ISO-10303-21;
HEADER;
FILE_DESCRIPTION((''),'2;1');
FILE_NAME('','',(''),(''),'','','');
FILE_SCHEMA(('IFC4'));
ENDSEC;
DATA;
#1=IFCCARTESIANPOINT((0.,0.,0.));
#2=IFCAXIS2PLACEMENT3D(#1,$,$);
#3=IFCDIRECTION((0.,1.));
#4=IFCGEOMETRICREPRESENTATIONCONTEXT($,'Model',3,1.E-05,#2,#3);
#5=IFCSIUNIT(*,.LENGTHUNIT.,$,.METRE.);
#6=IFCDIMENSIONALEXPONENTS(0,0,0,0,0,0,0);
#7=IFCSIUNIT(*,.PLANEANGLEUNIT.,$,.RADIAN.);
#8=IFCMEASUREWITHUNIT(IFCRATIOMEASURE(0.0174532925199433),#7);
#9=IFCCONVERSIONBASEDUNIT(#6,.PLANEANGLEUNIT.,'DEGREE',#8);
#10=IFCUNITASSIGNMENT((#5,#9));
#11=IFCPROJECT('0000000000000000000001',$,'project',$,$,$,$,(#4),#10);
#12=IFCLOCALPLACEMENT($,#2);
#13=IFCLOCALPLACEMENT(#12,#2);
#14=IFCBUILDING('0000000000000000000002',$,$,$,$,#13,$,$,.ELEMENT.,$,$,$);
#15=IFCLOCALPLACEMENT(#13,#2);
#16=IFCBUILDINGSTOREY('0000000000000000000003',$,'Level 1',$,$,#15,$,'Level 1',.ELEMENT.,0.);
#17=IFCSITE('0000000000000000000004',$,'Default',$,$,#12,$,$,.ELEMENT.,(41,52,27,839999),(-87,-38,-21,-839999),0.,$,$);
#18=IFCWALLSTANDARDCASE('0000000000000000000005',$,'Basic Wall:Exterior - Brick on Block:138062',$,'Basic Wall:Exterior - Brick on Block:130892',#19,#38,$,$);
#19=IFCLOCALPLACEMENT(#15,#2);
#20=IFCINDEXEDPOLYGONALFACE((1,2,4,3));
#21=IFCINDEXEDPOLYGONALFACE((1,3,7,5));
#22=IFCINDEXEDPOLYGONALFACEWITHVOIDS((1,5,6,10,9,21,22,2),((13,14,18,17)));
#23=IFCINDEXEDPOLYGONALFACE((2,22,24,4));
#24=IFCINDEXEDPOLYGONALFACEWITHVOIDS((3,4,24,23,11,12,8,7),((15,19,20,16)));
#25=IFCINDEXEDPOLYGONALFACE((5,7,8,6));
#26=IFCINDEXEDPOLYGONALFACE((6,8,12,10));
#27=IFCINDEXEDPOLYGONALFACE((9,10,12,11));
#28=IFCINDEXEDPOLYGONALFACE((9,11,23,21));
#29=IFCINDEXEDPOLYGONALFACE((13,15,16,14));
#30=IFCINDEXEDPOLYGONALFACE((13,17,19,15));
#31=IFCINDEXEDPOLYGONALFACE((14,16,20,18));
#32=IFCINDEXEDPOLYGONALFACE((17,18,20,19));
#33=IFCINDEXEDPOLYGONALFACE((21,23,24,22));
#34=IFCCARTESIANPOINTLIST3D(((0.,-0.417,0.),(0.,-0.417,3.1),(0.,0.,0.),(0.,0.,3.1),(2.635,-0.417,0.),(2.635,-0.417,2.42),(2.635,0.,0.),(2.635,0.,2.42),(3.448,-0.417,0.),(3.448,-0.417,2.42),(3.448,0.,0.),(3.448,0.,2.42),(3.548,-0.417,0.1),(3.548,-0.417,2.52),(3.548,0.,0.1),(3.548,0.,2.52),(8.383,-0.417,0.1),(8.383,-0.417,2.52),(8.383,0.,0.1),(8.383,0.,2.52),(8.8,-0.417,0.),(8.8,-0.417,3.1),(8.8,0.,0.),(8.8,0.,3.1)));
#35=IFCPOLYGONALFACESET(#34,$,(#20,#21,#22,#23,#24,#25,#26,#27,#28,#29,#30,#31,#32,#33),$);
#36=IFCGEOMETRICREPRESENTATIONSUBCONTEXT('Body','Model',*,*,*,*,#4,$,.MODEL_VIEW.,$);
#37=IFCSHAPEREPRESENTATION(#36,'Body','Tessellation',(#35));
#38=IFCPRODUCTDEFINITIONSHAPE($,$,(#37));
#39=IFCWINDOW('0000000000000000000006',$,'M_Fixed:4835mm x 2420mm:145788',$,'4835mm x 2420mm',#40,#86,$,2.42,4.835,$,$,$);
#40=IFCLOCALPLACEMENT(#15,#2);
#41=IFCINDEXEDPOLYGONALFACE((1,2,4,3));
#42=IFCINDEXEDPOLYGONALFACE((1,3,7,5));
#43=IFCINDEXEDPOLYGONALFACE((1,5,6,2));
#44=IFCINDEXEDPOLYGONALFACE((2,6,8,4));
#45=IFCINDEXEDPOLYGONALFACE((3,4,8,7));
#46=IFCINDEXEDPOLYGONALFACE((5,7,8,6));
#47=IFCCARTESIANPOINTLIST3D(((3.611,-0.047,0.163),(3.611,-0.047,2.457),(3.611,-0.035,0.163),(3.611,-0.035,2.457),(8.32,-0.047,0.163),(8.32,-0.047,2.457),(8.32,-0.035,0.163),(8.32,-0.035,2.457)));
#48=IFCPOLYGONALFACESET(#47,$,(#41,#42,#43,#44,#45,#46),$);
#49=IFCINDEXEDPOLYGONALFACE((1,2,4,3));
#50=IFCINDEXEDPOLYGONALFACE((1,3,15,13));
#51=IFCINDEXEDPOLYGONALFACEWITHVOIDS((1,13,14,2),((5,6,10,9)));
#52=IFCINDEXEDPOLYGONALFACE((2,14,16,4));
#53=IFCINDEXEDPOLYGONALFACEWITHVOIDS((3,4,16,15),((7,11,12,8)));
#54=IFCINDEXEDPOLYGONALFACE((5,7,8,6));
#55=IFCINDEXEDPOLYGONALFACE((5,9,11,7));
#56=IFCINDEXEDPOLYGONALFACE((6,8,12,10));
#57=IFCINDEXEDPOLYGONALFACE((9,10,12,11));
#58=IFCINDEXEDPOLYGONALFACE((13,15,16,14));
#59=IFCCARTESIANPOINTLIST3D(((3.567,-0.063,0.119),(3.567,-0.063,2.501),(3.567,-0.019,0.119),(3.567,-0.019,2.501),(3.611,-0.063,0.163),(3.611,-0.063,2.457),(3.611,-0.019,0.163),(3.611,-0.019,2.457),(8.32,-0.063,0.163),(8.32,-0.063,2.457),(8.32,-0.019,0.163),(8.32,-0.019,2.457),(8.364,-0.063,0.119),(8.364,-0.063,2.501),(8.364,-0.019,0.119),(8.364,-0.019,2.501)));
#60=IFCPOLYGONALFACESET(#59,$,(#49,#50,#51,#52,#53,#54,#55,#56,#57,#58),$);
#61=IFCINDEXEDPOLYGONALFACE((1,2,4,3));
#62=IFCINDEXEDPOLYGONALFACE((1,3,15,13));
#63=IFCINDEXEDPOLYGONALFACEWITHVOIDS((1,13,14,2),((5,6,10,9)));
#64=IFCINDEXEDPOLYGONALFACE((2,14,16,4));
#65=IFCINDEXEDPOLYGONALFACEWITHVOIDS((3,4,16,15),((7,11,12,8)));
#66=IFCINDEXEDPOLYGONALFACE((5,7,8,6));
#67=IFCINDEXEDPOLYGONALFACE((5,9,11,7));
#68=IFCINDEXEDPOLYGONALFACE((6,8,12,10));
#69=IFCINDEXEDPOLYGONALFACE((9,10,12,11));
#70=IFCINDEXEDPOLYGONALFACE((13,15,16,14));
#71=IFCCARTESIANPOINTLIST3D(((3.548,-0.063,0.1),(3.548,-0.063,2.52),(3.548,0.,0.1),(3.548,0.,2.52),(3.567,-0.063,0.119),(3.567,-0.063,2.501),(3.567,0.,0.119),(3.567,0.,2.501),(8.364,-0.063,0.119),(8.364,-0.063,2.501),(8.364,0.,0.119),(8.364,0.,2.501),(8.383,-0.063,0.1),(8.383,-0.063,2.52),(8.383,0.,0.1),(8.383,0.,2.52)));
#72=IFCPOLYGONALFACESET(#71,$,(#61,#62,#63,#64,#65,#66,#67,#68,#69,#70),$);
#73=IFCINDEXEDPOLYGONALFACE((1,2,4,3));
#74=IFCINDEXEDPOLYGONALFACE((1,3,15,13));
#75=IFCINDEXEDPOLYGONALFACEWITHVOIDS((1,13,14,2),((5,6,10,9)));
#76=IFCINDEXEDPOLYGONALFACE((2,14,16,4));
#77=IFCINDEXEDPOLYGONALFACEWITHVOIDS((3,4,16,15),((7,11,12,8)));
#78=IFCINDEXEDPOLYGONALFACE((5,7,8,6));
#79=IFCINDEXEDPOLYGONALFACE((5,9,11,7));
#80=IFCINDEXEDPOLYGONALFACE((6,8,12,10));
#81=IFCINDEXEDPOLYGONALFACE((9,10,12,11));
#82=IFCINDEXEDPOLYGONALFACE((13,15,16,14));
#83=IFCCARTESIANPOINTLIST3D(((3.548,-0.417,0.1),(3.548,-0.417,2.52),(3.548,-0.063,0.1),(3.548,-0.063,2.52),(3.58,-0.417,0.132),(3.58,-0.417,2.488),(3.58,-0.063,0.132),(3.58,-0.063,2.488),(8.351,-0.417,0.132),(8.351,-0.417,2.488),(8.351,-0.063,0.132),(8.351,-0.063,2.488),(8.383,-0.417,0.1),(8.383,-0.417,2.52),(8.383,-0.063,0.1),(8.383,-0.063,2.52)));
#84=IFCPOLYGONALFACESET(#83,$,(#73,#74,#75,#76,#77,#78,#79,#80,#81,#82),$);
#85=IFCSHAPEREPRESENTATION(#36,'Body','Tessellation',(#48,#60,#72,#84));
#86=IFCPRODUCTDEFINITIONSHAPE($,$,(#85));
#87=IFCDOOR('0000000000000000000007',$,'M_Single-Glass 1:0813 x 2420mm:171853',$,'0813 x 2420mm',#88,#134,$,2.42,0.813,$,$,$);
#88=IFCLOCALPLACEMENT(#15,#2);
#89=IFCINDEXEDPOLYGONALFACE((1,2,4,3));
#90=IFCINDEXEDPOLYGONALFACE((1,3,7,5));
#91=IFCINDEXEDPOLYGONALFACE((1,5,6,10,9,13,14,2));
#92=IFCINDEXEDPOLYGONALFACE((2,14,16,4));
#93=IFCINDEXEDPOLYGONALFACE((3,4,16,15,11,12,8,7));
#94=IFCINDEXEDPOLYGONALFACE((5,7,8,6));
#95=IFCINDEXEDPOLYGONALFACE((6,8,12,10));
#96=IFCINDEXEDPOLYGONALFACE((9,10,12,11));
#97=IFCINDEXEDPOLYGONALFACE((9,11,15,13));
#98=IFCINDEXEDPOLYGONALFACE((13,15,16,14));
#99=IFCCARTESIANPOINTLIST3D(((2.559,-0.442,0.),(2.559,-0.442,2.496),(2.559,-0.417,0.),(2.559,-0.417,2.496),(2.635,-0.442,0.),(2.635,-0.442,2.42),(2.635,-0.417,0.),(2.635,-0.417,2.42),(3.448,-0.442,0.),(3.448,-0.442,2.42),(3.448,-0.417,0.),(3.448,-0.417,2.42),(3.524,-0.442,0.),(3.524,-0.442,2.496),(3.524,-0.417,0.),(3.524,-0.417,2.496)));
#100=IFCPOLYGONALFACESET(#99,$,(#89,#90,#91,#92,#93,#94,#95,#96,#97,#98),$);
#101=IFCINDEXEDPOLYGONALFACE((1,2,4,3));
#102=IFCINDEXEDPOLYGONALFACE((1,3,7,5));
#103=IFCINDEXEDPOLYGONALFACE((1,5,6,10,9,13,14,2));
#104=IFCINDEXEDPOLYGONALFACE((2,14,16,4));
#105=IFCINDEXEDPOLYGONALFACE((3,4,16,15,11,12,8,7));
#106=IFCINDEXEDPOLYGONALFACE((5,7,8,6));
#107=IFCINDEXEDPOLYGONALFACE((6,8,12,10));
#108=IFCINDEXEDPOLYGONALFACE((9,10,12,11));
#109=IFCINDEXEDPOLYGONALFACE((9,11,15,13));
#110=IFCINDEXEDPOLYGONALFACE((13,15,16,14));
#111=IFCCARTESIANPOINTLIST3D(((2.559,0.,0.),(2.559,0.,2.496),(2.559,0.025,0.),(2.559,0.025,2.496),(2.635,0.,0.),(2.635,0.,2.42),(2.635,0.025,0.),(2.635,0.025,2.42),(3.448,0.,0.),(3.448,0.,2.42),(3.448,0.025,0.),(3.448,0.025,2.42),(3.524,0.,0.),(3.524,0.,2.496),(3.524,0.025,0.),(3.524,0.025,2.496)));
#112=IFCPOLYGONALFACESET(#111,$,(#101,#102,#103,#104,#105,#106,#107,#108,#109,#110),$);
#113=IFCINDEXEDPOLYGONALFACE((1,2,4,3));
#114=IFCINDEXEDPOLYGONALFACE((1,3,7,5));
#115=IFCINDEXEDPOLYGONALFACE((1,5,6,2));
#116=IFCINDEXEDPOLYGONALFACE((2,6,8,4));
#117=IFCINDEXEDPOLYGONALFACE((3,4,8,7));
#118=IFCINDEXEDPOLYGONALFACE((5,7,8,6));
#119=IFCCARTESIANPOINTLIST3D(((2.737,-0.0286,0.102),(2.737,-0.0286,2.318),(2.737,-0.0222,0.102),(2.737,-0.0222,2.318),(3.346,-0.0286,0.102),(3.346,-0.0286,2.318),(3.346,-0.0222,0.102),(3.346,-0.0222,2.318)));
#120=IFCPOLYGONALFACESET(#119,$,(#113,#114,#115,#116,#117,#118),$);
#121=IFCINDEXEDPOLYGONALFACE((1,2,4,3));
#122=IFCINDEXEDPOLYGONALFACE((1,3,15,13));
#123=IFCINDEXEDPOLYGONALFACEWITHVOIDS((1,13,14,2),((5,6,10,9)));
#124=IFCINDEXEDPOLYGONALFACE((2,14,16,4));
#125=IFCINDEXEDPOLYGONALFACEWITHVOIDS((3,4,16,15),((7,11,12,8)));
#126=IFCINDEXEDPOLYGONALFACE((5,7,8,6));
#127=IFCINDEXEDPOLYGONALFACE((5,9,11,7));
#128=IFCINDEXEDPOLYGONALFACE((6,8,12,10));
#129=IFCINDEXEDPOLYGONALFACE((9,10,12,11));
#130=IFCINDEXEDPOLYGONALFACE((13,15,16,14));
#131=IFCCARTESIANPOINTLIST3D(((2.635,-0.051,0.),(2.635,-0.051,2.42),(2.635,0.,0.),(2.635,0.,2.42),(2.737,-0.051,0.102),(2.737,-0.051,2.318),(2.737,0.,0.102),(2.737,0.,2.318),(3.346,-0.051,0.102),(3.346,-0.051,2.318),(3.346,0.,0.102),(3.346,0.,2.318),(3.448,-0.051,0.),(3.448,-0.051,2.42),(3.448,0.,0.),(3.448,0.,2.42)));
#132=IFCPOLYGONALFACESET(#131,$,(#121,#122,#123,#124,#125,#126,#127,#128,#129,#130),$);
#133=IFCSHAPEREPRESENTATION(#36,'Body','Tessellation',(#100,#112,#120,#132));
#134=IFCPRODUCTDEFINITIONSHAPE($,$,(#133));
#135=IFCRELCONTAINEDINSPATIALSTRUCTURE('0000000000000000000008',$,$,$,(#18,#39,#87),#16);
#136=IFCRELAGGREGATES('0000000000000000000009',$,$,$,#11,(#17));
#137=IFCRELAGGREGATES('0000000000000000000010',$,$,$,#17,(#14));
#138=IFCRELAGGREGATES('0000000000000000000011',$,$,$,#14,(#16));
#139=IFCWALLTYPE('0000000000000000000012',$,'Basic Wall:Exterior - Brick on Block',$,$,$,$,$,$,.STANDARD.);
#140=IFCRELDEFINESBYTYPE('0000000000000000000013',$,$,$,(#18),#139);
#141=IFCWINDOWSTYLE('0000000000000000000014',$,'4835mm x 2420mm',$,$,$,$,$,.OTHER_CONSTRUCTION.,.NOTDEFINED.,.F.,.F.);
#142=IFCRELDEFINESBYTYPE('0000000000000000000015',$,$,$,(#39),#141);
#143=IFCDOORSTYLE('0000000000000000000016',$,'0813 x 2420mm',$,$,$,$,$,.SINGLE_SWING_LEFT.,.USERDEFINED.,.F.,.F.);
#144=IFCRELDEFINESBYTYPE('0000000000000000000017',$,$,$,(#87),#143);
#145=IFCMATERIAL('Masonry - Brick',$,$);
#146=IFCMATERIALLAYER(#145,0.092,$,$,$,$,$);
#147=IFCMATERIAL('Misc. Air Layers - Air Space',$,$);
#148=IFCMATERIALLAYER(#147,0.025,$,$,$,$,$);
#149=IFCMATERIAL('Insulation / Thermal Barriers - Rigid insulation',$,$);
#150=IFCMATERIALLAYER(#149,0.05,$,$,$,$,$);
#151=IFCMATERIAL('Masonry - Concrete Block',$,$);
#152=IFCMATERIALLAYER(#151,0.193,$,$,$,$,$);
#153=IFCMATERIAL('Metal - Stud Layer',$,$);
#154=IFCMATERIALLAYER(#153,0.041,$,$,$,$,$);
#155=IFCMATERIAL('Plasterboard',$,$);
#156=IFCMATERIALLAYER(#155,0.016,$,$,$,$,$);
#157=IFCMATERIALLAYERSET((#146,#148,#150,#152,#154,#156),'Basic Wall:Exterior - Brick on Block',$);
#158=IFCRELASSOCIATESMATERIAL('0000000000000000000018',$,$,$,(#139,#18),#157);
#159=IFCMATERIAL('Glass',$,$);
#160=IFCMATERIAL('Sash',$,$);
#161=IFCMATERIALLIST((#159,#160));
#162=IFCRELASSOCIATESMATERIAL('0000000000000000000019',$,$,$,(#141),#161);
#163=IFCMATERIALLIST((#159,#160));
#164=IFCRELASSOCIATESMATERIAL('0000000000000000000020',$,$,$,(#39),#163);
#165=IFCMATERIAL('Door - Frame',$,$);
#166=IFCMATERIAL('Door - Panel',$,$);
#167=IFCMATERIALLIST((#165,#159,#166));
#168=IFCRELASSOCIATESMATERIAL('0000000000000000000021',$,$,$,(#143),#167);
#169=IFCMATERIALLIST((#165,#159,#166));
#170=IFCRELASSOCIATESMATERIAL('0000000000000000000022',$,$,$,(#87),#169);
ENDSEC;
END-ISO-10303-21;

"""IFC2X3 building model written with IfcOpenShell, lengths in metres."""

from ifc_helpers import new_model, entity, si_unit, converted_unit, direction, frame, frame_2d, origin, origin_2d_with_axis, place, context, subcontext, project, spatial, polyline, rectangle, outline, extrude, source, transform, mapped, material, material_list, layer, layer_set, layer_usage, type_object, type_shapes, element, fill, save


model = new_model("IFC2X3")

# Units and contexts
model_context = context("Model", 3, precision=1e-05, world=origin(), true_north=direction((0.0, 1.0)))
body_context = subcontext(model_context, "Body", "Model", "MODEL_VIEW")
ifc_project = project(units=[si_unit("LENGTHUNIT", "METRE"), converted_unit("PLANEANGLEUNIT", "DEGREE", entity("IfcRatioMeasure", 0.0174532925199433), si_unit("PLANEANGLEUNIT", "RADIAN"), dimensions=[0, 0, 0, 0, 0, 0, 0])], contexts=[model_context])

# Site, building, storey
site_placement = place(None, origin())
site = spatial("IfcSite", under=ifc_project, at=site_placement, Name="Default", CompositionType="ELEMENT", RefLatitude=(41, 52, 27, 839999), RefLongitude=(-87, -38, -21, -839999), RefElevation=0.0)
building_placement = place(site_placement, origin())
building = spatial("IfcBuilding", under=site, at=building_placement, CompositionType="ELEMENT")
storey_placement = place(building_placement, origin())
storey = spatial("IfcBuildingStorey", under=building, at=storey_placement, Name="Level 1", LongName="Level 1", CompositionType="ELEMENT", Elevation=0.0)

# Wall, openings, window, door
ifc_material_1 = material(Name="Masonry - Brick")
ifc_layer_1 = layer(ifc_material_1, 0.092)
ifc_material_2 = material(Name="Misc. Air Layers - Air Space")
ifc_layer_2 = layer(ifc_material_2, 0.025)
ifc_material_3 = material(Name="Insulation / Thermal Barriers - Rigid insulation")
ifc_layer_3 = layer(ifc_material_3, 0.05)
ifc_material_4 = material(Name="Masonry - Concrete Block")
ifc_layer_4 = layer(ifc_material_4, 0.193)
ifc_material_5 = material(Name="Metal - Stud Layer")
ifc_layer_5 = layer(ifc_material_5, 0.041)
ifc_material_6 = material(Name="Plasterboard")
ifc_layer_6 = layer(ifc_material_6, 0.016)
ifc_layer_set_1 = layer_set([ifc_layer_1, ifc_layer_2, ifc_layer_3, ifc_layer_4, ifc_layer_5, ifc_layer_6], Name="Basic Wall:Exterior - Brick on Block")
ifc_layer_usage_1 = layer_usage(ifc_layer_set_1, "AXIS2", "NEGATIVE", 0.2085)
wall_type_1 = type_object("IfcWallType", Name="Basic Wall:Exterior - Brick on Block", PredefinedType="STANDARD", material=ifc_layer_set_1)
wall_1_placement = place(storey_placement, frame((0.0, -0.2085, 0.0)))
wall_1 = element("IfcWallStandardCase", 1, at=wall_1_placement, inside=storey, type_object=wall_type_1, material=ifc_layer_usage_1, Name="Basic Wall:Exterior - Brick on Block:138062", ObjectType="Basic Wall:Exterior - Brick on Block:130892", context=body_context, shape_type="SweptSolid", body=[
    extrude(rectangle(XDim=8.8, YDim=0.417, at=frame_2d((4.4, 0.0), x_axis=(-1.0, 0.0))), origin(), (0.0, 0.0, 1.0), 3.1),
])
opening_1_placement = place(wall_1_placement, frame((2.635, -0.2085, 0.0)))
opening_1 = element("IfcOpeningElement", 2, at=opening_1_placement, cuts=wall_1, ObjectType="Opening", context=body_context, shape_type="SweptSolid", body=[
    extrude(rectangle(XDim=0.813, YDim=2.42, at=frame_2d((1.21, 0.4065), x_axis=(0.0, -1.0))), frame((0.0, 0.0, 0.0), z_axis=(0.0, 1.0, 0.0), x_axis=(0.0, 0.0, 1.0)), (0.0, 0.0, 1.0), 0.417),
])
opening_2_placement = place(wall_1_placement, frame((3.548, -0.2085, 0.1)))
opening_2 = element("IfcOpeningElement", 3, at=opening_2_placement, cuts=wall_1, ObjectType="Opening", context=body_context, shape_type="SweptSolid", body=[
    extrude(rectangle(XDim=2.42, YDim=4.835, at=frame_2d((1.21, 2.4175), x_axis=(1.0, 0.0))), frame((0.0, 0.0, 0.0), z_axis=(0.0, 1.0, 0.0), x_axis=(0.0, 0.0, 1.0)), (0.0, 0.0, 1.0), 0.417),
])
ifc_material_7 = material(Name="Glass")
ifc_material_8 = material(Name="Sash")
ifc_material_list_1 = material_list([ifc_material_7, ifc_material_8])
ifc_material_list_2 = material_list([ifc_material_7, ifc_material_8])
window_style_1 = type_object("IfcWindowStyle", Name="4835mm x 2420mm", ConstructionType="OTHER_CONSTRUCTION", OperationType="NOTDEFINED", ParameterTakesPrecedence=False, Sizeable=False, material=ifc_material_list_2)
shared_shape_1 = source(origin(), body_context, "Body", "SweptSolid", [
    extrude(rectangle(XDim=0.012, YDim=4.709, at=origin_2d_with_axis()), frame((2.4175, 0.376, 0.063), z_axis=(0.0, 0.0, 1.0), x_axis=(0.0, -1.0, 0.0)), (0.0, 0.0, 1.0), 2.294),
    extrude(outline(polyline([(-2.3985, -1.191), (2.3985, -1.191), (2.3985, 1.191), (-2.3985, 1.191), (-2.3985, -1.191)]), holes=[polyline([(-2.3545, -1.147), (-2.3545, 1.147), (2.3545, 1.147), (2.3545, -1.147), (-2.3545, -1.147)])]), frame((2.4175, 0.354, 1.21), z_axis=(0.0, 1.0, 0.0), x_axis=(1.0, 0.0, 0.0)), (0.0, 0.0, 1.0), 0.044),
    extrude(outline(polyline([(-2.4175, -1.21), (2.4175, -1.21), (2.4175, 1.21), (-2.4175, 1.21), (-2.4175, -1.21)]), holes=[polyline([(-2.3985, -1.191), (-2.3985, 1.191), (2.3985, 1.191), (2.3985, -1.191), (-2.3985, -1.191)])]), frame((2.4175, 0.354, 1.21), z_axis=(0.0, 1.0, 0.0), x_axis=(1.0, 0.0, 0.0)), (0.0, 0.0, 1.0), 0.063),
    extrude(outline(polyline([(-2.4175, -1.21), (2.4175, -1.21), (2.4175, 1.21), (-2.4175, 1.21), (-2.4175, -1.21)]), holes=[polyline([(-2.3855, -1.178), (-2.3855, 1.178), (2.3855, 1.178), (2.3855, -1.178), (-2.3855, -1.178)])]), frame((2.4175, 0.0, 1.21), z_axis=(0.0, 1.0, 0.0), x_axis=(1.0, 0.0, 0.0)), (0.0, 0.0, 1.0), 0.354),
])
type_shapes(window_style_1, [shared_shape_1])
window_1_placement = place(opening_2_placement, origin())
window_1 = element("IfcWindow", 4, at=window_1_placement, inside=storey, type_object=window_style_1, material=ifc_material_list_1, Name="M_Fixed:4835mm x 2420mm:145788", ObjectType="4835mm x 2420mm", OverallHeight=2.42, OverallWidth=4.835, context=body_context, shape_type="MappedRepresentation", body=[
    mapped(shared_shape_1, transform((0.0, 0.0, 0.0), scale=1.0)),
])
fill(opening_2, window_1)
ifc_material_9 = material(Name="Door - Frame")
ifc_material_10 = material(Name="Door - Panel")
ifc_material_list_3 = material_list([ifc_material_9, ifc_material_7, ifc_material_10])
ifc_material_list_4 = material_list([ifc_material_9, ifc_material_7, ifc_material_10])
door_style_1 = type_object("IfcDoorStyle", Name="0813 x 2420mm", ConstructionType="USERDEFINED", OperationType="SINGLE_SWING_LEFT", ParameterTakesPrecedence=False, Sizeable=False, material=ifc_material_list_4)
shared_shape_2 = source(origin(), body_context, "Body", "SweptSolid", [
    extrude(outline(polyline([(-0.4065, -1.191), (-0.4065, 1.229), (-0.4825, 1.229), (-0.4825, -1.267), (0.4825, -1.267), (0.4825, 1.229), (0.4065, 1.229), (0.4065, -1.191), (-0.4065, -1.191)])), frame((0.4065, 0.0, 1.229), z_axis=(0.0, 1.0, 0.0), x_axis=(1.0, 0.0, 0.0)), (0.0, 0.0, -1.0), 0.025),
    extrude(outline(polyline([(-0.4065, -1.191), (-0.4065, 1.229), (-0.4825, 1.229), (-0.4825, -1.267), (0.4825, -1.267), (0.4825, 1.229), (0.4065, 1.229), (0.4065, -1.191), (-0.4065, -1.191)])), frame((0.4065, 0.442, 1.229), z_axis=(0.0, 1.0, 0.0), x_axis=(1.0, 0.0, 0.0)), (0.0, 0.0, -1.0), 0.025),
    extrude(rectangle(XDim=0.609, YDim=0.0064, at=frame_2d((0.0, 0.0), x_axis=(1.0, 0.0))), frame((0.4065, 0.3916, 0.102)), (0.0, 0.0, 1.0), 2.216),
    extrude(outline(polyline([(-1.21, -0.4065), (1.21, -0.4065), (1.21, 0.4065), (-1.21, 0.4065), (-1.21, -0.4065)]), holes=[polyline([(-1.108, 0.3045), (1.108, 0.3045), (1.108, -0.3045), (-1.108, -0.3045), (-1.108, 0.3045)])]), frame((0.4065, 0.417, 1.21), z_axis=(0.0, -1.0, 0.0), x_axis=(0.0, 0.0, -1.0)), (0.0, 0.0, 1.0), 0.051),
])
type_shapes(door_style_1, [shared_shape_2])
door_1_placement = place(opening_1_placement, origin())
door_1 = element("IfcDoor", 5, at=door_1_placement, inside=storey, type_object=door_style_1, material=ifc_material_list_3, Name="M_Single-Glass 1:0813 x 2420mm:171853", ObjectType="0813 x 2420mm", OverallHeight=2.42, OverallWidth=0.813, context=body_context, shape_type="MappedRepresentation", body=[
    mapped(shared_shape_2, transform((0.0, 0.0, 0.0), scale=1.0)),
])
fill(opening_1, door_1)

save(model, "model.ifc")
